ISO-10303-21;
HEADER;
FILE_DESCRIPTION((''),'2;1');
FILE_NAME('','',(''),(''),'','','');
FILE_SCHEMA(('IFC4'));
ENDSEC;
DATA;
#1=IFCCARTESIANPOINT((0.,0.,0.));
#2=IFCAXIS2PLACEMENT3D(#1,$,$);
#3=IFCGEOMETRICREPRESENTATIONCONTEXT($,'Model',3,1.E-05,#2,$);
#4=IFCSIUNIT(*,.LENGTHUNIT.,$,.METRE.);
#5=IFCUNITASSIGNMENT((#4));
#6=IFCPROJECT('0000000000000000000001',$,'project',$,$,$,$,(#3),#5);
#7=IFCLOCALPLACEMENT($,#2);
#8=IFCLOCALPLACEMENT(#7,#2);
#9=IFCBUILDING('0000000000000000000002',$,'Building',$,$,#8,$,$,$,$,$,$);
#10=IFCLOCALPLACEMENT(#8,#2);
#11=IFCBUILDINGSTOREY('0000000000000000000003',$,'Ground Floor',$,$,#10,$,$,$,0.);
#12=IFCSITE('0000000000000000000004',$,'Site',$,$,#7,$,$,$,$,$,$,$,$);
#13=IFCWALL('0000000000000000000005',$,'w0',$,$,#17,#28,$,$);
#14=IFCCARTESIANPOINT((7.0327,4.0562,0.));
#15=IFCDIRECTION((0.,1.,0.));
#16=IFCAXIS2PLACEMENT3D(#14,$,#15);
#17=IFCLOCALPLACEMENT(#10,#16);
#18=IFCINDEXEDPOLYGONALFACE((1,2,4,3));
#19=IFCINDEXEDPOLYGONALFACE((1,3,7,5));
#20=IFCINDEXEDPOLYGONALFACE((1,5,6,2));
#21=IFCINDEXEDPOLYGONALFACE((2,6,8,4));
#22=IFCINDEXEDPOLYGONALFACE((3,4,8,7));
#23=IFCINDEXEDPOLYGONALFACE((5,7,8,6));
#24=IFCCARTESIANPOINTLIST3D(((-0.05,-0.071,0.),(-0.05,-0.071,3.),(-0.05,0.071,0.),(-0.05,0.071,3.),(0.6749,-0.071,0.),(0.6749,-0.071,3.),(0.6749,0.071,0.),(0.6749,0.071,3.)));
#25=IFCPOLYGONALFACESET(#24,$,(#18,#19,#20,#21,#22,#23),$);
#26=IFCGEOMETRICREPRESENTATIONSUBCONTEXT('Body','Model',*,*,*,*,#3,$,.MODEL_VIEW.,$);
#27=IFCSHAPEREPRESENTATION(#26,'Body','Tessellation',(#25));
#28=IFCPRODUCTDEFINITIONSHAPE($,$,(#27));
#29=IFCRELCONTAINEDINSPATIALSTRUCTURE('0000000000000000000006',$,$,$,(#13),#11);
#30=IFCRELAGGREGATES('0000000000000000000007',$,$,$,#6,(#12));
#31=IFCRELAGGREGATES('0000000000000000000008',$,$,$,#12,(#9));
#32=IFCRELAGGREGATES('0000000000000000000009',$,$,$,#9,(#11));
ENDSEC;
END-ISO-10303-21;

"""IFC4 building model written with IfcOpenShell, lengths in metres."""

from ifc_helpers import new_model, si_unit, frame, origin, place, context, subcontext, project, spatial, polyline, outline, extrude, element, save


model = new_model("IFC4")

# Units and contexts
model_context = context("Model", 3, precision=1e-05, world=origin())
body_context = subcontext(model_context, "Body", "Model", "MODEL_VIEW")
ifc_project = project(units=[si_unit("LENGTHUNIT", "METRE")], contexts=[model_context])

# Site, building, storey
site_placement = place(None, origin())
site = spatial("IfcSite", under=ifc_project, at=site_placement, Name="Site")
building_placement = place(site_placement, origin())
building = spatial("IfcBuilding", under=site, at=building_placement, Name="Building")
storey_placement = place(building_placement, origin())
storey = spatial("IfcBuildingStorey", under=building, at=storey_placement, Name="Ground Floor", Elevation=0.0)

# Wall
wall_1_placement = place(storey_placement, frame((7.0327, 4.0562, 0.0), x_axis=(0.0, 1.0, 0.0)))
element("IfcWall", 1, at=wall_1_placement, inside=storey, Name="w0", context=body_context, shape_type="SweptSolid", body=[
    extrude(outline(polyline([(-0.05, -0.071), (0.6749, -0.071), (0.6749, 0.071), (-0.05, 0.071), (-0.05, -0.071)])), origin(), (0.0, 0.0, 1.0), 3.0),
])

save(model, "model.ifc")
